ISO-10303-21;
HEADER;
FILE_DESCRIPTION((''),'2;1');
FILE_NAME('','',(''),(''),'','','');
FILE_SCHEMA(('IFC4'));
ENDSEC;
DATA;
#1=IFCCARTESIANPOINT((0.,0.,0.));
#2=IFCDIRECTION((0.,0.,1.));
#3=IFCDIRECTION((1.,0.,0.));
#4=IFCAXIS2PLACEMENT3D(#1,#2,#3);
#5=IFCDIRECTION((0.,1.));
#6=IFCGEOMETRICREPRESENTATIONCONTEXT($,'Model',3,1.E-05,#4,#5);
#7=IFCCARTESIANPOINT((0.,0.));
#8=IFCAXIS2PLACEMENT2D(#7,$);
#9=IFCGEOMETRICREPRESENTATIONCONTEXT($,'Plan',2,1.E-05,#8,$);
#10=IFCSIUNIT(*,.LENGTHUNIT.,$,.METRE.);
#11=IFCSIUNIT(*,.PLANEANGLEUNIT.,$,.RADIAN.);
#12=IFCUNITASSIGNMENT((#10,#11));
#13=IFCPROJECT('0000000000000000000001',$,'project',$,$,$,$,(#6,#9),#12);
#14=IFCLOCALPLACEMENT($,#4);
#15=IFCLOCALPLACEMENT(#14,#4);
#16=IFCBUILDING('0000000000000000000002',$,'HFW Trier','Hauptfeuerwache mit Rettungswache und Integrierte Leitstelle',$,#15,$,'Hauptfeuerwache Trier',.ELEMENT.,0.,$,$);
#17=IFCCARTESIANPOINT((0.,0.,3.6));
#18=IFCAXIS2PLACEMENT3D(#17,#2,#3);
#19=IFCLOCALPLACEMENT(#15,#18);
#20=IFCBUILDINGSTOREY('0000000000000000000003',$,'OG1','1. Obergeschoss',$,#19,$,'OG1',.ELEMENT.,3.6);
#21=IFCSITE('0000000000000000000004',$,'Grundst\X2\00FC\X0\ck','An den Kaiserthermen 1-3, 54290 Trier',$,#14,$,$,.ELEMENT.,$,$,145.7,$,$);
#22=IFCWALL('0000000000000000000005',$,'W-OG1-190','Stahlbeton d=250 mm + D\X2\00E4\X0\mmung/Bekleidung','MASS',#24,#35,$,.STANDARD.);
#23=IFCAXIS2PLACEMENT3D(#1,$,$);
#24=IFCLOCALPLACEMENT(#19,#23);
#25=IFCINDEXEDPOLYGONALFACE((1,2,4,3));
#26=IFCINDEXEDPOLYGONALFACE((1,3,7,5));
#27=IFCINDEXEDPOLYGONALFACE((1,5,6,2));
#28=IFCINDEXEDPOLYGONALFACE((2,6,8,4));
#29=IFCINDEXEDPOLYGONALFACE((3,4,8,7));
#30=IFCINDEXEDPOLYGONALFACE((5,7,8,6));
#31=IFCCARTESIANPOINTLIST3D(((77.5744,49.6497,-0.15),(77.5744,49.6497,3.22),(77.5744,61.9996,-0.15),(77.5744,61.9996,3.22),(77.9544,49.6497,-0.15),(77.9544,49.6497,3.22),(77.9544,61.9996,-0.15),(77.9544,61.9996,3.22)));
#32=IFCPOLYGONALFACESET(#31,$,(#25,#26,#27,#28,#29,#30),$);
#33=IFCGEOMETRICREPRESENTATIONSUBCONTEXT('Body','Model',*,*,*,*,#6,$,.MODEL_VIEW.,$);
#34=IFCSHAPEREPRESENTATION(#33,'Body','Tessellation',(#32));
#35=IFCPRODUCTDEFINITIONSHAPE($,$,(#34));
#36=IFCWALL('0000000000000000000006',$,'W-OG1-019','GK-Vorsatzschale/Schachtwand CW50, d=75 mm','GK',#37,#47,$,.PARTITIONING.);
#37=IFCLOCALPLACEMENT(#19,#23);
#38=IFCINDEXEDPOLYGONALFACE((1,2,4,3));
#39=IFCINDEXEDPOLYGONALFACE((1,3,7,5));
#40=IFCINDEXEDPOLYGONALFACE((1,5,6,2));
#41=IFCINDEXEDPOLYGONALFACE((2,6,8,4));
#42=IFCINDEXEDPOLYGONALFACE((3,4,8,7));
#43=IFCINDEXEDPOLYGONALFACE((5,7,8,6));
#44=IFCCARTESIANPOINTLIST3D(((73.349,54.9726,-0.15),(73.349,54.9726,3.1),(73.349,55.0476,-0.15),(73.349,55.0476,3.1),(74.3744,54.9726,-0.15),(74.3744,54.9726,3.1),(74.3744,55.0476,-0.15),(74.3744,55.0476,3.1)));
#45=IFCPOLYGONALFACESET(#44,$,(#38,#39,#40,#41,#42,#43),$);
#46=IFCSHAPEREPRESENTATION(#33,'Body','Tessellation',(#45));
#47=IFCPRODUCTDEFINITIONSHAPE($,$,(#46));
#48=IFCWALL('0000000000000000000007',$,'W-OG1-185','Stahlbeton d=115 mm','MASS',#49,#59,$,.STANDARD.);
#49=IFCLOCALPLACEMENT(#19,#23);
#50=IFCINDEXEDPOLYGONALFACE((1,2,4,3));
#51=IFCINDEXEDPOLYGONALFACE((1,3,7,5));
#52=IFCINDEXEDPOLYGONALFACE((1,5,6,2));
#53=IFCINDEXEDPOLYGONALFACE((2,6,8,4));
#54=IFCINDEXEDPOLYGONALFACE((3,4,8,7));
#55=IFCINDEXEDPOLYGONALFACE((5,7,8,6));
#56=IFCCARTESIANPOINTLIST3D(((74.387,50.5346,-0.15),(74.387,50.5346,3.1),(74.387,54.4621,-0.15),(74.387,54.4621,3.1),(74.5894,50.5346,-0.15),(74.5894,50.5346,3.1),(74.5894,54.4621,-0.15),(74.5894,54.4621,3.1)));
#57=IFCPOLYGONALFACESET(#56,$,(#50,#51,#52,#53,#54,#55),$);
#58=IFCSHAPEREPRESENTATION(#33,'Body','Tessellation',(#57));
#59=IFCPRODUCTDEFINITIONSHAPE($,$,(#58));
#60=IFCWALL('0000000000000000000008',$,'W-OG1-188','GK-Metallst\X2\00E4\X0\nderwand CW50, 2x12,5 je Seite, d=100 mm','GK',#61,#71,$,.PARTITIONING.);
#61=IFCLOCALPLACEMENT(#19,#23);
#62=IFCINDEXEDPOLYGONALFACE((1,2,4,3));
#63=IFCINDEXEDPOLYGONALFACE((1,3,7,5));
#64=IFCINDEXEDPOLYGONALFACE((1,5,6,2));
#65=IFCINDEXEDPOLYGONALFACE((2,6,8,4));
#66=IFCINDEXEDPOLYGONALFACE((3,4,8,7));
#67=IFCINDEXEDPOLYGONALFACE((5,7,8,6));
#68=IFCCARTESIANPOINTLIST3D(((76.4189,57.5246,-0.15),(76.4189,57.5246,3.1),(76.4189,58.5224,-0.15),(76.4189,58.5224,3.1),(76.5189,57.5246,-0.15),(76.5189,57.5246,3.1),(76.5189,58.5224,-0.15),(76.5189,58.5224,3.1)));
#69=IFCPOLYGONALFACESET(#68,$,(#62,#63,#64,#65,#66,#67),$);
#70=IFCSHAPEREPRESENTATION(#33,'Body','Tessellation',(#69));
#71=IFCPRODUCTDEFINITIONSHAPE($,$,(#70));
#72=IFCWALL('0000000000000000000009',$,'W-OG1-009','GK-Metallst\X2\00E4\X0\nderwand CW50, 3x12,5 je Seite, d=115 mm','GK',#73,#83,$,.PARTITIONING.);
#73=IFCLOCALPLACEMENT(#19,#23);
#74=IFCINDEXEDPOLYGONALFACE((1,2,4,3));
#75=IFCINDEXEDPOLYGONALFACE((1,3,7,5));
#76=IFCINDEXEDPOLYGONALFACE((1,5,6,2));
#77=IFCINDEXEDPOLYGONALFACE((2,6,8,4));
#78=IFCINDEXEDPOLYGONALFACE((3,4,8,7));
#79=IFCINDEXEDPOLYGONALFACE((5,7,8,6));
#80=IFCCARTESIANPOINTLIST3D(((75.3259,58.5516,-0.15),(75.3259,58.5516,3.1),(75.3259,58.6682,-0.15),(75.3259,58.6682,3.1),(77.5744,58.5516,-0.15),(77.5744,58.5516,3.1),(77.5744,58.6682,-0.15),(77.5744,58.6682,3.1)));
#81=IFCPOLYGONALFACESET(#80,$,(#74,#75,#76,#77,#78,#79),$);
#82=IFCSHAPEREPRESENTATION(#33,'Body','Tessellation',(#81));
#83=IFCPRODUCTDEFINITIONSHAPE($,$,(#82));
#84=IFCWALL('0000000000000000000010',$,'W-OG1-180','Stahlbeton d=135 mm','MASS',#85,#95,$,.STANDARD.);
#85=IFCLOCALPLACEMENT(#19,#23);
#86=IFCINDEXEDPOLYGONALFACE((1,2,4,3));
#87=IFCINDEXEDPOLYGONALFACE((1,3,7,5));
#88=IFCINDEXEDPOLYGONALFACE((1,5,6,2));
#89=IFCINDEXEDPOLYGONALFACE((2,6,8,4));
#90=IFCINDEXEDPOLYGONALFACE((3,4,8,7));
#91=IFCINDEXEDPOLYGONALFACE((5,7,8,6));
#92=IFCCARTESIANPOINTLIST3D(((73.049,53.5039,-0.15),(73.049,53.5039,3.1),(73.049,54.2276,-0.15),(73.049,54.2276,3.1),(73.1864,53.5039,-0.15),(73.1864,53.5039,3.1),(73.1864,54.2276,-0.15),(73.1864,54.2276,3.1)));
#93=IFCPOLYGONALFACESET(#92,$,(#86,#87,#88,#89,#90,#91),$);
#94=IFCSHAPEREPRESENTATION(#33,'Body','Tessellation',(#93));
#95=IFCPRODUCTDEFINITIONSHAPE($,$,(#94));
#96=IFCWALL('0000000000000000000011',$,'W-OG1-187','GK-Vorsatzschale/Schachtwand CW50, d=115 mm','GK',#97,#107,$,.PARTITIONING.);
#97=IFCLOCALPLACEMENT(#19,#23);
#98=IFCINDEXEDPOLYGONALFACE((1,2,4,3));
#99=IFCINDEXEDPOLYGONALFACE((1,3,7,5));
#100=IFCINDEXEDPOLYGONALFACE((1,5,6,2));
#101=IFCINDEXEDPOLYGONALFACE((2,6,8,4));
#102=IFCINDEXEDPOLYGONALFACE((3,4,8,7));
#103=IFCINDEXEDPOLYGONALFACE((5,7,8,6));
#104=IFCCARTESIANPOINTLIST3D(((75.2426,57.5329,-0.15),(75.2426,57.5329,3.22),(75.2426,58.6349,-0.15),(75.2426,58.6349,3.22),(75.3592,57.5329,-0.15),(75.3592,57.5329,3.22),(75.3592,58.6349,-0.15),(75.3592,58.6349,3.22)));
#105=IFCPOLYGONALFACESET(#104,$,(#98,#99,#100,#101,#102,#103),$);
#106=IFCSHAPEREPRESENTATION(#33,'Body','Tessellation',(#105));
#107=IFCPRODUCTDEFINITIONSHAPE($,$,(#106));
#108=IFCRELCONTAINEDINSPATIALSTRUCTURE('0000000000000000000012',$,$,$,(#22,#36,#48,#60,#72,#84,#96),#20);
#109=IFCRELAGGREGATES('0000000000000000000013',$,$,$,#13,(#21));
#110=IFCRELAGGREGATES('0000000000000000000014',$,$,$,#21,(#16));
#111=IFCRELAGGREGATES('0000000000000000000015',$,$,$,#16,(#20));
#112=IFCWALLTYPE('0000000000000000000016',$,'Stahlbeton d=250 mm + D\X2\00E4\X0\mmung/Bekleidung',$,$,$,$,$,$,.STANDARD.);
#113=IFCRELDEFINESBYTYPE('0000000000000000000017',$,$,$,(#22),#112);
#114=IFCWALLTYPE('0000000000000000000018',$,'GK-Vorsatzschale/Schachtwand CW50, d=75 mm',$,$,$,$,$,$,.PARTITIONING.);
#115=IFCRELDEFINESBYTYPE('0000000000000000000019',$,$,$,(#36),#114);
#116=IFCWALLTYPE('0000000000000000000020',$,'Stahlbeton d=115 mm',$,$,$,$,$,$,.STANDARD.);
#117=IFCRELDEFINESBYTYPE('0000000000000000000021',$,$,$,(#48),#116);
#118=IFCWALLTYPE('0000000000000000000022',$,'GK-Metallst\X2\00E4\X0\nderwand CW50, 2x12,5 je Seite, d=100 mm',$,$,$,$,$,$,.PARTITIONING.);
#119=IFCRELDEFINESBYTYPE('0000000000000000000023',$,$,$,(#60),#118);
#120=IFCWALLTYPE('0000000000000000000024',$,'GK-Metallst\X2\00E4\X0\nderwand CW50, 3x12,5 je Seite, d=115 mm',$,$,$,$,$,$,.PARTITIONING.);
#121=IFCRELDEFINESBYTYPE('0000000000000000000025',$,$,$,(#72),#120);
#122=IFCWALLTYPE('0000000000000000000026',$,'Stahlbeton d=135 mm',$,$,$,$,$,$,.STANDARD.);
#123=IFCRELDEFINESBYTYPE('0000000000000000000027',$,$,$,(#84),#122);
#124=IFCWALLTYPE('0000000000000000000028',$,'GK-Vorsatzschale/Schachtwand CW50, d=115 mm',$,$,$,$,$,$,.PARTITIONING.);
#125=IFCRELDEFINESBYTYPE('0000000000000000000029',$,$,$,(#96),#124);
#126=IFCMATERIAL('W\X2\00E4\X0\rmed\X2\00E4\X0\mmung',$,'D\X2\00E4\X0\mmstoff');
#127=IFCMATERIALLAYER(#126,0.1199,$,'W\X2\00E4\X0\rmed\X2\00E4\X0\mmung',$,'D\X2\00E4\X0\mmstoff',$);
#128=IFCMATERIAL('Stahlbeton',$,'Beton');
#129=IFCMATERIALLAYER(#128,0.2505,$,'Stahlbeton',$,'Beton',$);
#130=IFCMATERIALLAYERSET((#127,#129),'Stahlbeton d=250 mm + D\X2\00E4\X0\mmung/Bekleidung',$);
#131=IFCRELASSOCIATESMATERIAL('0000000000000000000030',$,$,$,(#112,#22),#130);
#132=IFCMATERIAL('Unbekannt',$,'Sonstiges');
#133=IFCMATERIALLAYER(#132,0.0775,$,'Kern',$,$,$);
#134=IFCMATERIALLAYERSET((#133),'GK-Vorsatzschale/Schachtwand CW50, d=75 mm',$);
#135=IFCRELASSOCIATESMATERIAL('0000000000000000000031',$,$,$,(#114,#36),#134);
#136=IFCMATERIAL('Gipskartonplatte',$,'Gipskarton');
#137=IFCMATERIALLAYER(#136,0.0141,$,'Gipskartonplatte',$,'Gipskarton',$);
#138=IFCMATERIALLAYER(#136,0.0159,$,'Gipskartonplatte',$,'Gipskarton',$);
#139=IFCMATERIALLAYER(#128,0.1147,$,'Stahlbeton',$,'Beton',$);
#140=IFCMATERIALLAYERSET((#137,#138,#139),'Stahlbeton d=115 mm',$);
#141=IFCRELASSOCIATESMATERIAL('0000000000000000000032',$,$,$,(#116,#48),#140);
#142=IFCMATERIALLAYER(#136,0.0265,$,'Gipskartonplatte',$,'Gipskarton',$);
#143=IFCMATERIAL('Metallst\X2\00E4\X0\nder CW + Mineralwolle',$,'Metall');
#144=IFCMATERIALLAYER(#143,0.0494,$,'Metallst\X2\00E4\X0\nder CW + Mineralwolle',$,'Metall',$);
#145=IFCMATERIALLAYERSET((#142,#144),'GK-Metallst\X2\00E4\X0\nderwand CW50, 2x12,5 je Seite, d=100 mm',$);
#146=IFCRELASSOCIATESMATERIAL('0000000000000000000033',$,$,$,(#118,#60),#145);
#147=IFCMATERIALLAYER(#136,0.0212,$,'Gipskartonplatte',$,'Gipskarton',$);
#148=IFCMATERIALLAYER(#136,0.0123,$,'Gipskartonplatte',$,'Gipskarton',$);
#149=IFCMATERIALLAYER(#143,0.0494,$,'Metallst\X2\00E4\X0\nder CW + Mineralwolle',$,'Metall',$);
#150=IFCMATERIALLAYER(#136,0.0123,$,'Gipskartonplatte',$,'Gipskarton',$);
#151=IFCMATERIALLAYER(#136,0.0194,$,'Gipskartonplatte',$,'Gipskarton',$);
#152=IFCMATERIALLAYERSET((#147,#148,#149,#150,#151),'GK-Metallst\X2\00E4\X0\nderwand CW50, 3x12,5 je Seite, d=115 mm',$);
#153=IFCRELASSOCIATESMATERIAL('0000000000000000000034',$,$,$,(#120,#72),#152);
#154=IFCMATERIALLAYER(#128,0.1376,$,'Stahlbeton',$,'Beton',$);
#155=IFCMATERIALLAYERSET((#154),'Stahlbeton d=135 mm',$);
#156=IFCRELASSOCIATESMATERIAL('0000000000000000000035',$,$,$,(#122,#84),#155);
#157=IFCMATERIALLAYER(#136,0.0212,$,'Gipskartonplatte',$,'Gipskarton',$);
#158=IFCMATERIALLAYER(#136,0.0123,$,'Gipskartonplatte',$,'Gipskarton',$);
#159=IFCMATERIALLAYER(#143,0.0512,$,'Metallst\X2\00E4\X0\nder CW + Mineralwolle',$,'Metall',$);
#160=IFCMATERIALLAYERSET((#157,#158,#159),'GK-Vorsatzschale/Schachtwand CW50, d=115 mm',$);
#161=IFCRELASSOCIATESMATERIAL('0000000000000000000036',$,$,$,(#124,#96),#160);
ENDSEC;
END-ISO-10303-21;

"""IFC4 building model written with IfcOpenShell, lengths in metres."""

from ifc_helpers import new_model, si_unit, direction, frame, frame_2d, origin_with_axes, origin_2d, place, context, subcontext, project, spatial, rectangle, extrude, material, layer, layer_set, layer_usage, type_object, element, save


model = new_model("IFC4")

# Units and contexts
model_context = context("Model", 3, precision=1e-05, world=origin_with_axes(), true_north=direction((0.0, 1.0)))
plan_context = context("Plan", 2, precision=1e-05, world=origin_2d())
body_context = subcontext(model_context, "Body", "Model", "MODEL_VIEW")
ifc_project = project(units=[si_unit("LENGTHUNIT", "METRE"), si_unit("PLANEANGLEUNIT", "RADIAN")], contexts=[model_context, plan_context])

# Site, building, storey
site_placement = place(None, origin_with_axes())
site = spatial("IfcSite", under=ifc_project, at=site_placement, Name="Grundstück", Description="An den Kaiserthermen 1-3, 54290 Trier", CompositionType="ELEMENT", RefElevation=145.7)
building_placement = place(site_placement, origin_with_axes())
building = spatial("IfcBuilding", under=site, at=building_placement, Name="HFW Trier", Description="Hauptfeuerwache mit Rettungswache und Integrierte Leitstelle", LongName="Hauptfeuerwache Trier", CompositionType="ELEMENT", ElevationOfRefHeight=0.0)
storey_placement = place(building_placement, frame((0.0, 0.0, 3.6), z_axis=(0.0, 0.0, 1.0), x_axis=(1.0, 0.0, 0.0)))
storey = spatial("IfcBuildingStorey", under=building, at=storey_placement, Name="OG1", Description="1. Obergeschoss", LongName="OG1", CompositionType="ELEMENT", Elevation=3.6)

# Shared definitions
ifc_material_1 = material(Name="Gipskartonplatte", Category="Gipskarton")
ifc_material_2 = material(Name="Metallständer CW + Mineralwolle", Category="Metall")

# Shared definitions
ifc_material_3 = material(Name="Stahlbeton", Category="Beton")

# Walls
ifc_material_4 = material(Name="Wärmedämmung", Category="Dämmstoff")
ifc_layer_1 = layer(ifc_material_4, 0.1199, Name="Wärmedämmung", Category="Dämmstoff")
ifc_layer_2 = layer(ifc_material_3, 0.2505, Name="Stahlbeton", Category="Beton")
ifc_layer_set_1 = layer_set([ifc_layer_1, ifc_layer_2], Name="Stahlbeton d=250 mm + Dämmung/Bekleidung")
ifc_layer_usage_1 = layer_usage(ifc_layer_set_1, "AXIS2", "POSITIVE", -0.19)
wall_type_1 = type_object("IfcWallType", Name="Stahlbeton d=250 mm + Dämmung/Bekleidung", PredefinedType="STANDARD", material=ifc_layer_set_1)
wall_1_placement = place(storey_placement, frame((77.7644, 61.9996, -0.15), z_axis=(0.0, 0.0, 1.0), x_axis=(0.0, -1.0, 0.0)))
element("IfcWall", 1, at=wall_1_placement, inside=storey, type_object=wall_type_1, material=ifc_layer_usage_1, Name="W-OG1-190", Description="Stahlbeton d=250 mm + Dämmung/Bekleidung", ObjectType="MASS", PredefinedType="STANDARD", context=body_context, shape_type="SweptSolid", body=[
    extrude(rectangle(XDim=12.3499, YDim=0.38, at=frame_2d((6.1749, 0.0))), origin_with_axes(), (0.0, 0.0, 1.0), 3.37),
])
ifc_material_5 = material(Name="Unbekannt", Category="Sonstiges")
ifc_layer_3 = layer(ifc_material_5, 0.0775, Name="Kern")
ifc_layer_set_2 = layer_set([ifc_layer_3], Name="GK-Vorsatzschale/Schachtwand CW50, d=75 mm")
ifc_layer_usage_2 = layer_usage(ifc_layer_set_2, "AXIS2", "POSITIVE", -0.0375)
wall_type_2 = type_object("IfcWallType", Name="GK-Vorsatzschale/Schachtwand CW50, d=75 mm", PredefinedType="PARTITIONING", material=ifc_layer_set_2)
wall_2_placement = place(storey_placement, frame((73.349, 55.0101, -0.15), z_axis=(0.0, 0.0, 1.0), x_axis=(1.0, 0.0, 0.0)))
element("IfcWall", 2, at=wall_2_placement, inside=storey, type_object=wall_type_2, material=ifc_layer_usage_2, Name="W-OG1-019", Description="GK-Vorsatzschale/Schachtwand CW50, d=75 mm", ObjectType="GK", PredefinedType="PARTITIONING", context=body_context, shape_type="SweptSolid", body=[
    extrude(rectangle(XDim=1.0254, YDim=0.075, at=frame_2d((0.5127, 0.0))), origin_with_axes(), (0.0, 0.0, 1.0), 3.25),
])
ifc_layer_4 = layer(ifc_material_1, 0.0141, Name="Gipskartonplatte", Category="Gipskarton")
ifc_layer_5 = layer(ifc_material_1, 0.0159, Name="Gipskartonplatte", Category="Gipskarton")
ifc_layer_6 = layer(ifc_material_3, 0.1147, Name="Stahlbeton", Category="Beton")
ifc_layer_set_3 = layer_set([ifc_layer_4, ifc_layer_5, ifc_layer_6], Name="Stahlbeton d=115 mm")
ifc_layer_usage_3 = layer_usage(ifc_layer_set_3, "AXIS2", "POSITIVE", -0.1013)
wall_type_3 = type_object("IfcWallType", Name="Stahlbeton d=115 mm", PredefinedType="STANDARD", material=ifc_layer_set_3)
wall_3_placement = place(storey_placement, frame((74.4882, 54.4621, -0.15), z_axis=(0.0, 0.0, 1.0), x_axis=(0.0, -1.0, 0.0)))
element("IfcWall", 3, at=wall_3_placement, inside=storey, type_object=wall_type_3, material=ifc_layer_usage_3, Name="W-OG1-185", Description="Stahlbeton d=115 mm", ObjectType="MASS", PredefinedType="STANDARD", context=body_context, shape_type="SweptSolid", body=[
    extrude(rectangle(XDim=3.9275, YDim=0.2025, at=frame_2d((1.9638, 0.0))), origin_with_axes(), (0.0, 0.0, 1.0), 3.25),
])
ifc_layer_7 = layer(ifc_material_1, 0.0265, Name="Gipskartonplatte", Category="Gipskarton")
ifc_layer_8 = layer(ifc_material_2, 0.0494, Name="Metallständer CW + Mineralwolle", Category="Metall")
ifc_layer_set_4 = layer_set([ifc_layer_7, ifc_layer_8], Name="GK-Metallständerwand CW50, 2x12,5 je Seite, d=100 mm")
ifc_layer_usage_4 = layer_usage(ifc_layer_set_4, "AXIS2", "POSITIVE", -0.05)
wall_type_4 = type_object("IfcWallType", Name="GK-Metallständerwand CW50, 2x12,5 je Seite, d=100 mm", PredefinedType="PARTITIONING", material=ifc_layer_set_4)
wall_4_placement = place(storey_placement, frame((76.4689, 58.5224, -0.15), z_axis=(0.0, 0.0, 1.0), x_axis=(0.0, -1.0, 0.0)))
element("IfcWall", 4, at=wall_4_placement, inside=storey, type_object=wall_type_4, material=ifc_layer_usage_4, Name="W-OG1-188", Description="GK-Metallständerwand CW50, 2x12,5 je Seite, d=100 mm", ObjectType="GK", PredefinedType="PARTITIONING", context=body_context, shape_type="SweptSolid", body=[
    extrude(rectangle(XDim=0.9978, YDim=0.1, at=frame_2d((0.4989, 0.0))), origin_with_axes(), (0.0, 0.0, 1.0), 3.25),
])
ifc_layer_9 = layer(ifc_material_1, 0.0212, Name="Gipskartonplatte", Category="Gipskarton")
ifc_layer_10 = layer(ifc_material_1, 0.0123, Name="Gipskartonplatte", Category="Gipskarton")
ifc_layer_11 = layer(ifc_material_2, 0.0494, Name="Metallständer CW + Mineralwolle", Category="Metall")
ifc_layer_12 = layer(ifc_material_1, 0.0123, Name="Gipskartonplatte", Category="Gipskarton")
ifc_layer_13 = layer(ifc_material_1, 0.0194, Name="Gipskartonplatte", Category="Gipskarton")
ifc_layer_set_5 = layer_set([ifc_layer_9, ifc_layer_10, ifc_layer_11, ifc_layer_12, ifc_layer_13], Name="GK-Metallständerwand CW50, 3x12,5 je Seite, d=115 mm")
ifc_layer_usage_5 = layer_usage(ifc_layer_set_5, "AXIS2", "POSITIVE", -0.0583)
wall_type_5 = type_object("IfcWallType", Name="GK-Metallständerwand CW50, 3x12,5 je Seite, d=115 mm", PredefinedType="PARTITIONING", material=ifc_layer_set_5)
wall_5_placement = place(storey_placement, frame((75.3259, 58.6099, -0.15), z_axis=(0.0, 0.0, 1.0), x_axis=(1.0, 0.0, 0.0)))
element("IfcWall", 5, at=wall_5_placement, inside=storey, type_object=wall_type_5, material=ifc_layer_usage_5, Name="W-OG1-009", Description="GK-Metallständerwand CW50, 3x12,5 je Seite, d=115 mm", ObjectType="GK", PredefinedType="PARTITIONING", context=body_context, shape_type="SweptSolid", body=[
    extrude(rectangle(XDim=2.2485, YDim=0.1166, at=frame_2d((1.1242, 0.0))), origin_with_axes(), (0.0, 0.0, 1.0), 3.25),
])
ifc_layer_14 = layer(ifc_material_3, 0.1376, Name="Stahlbeton", Category="Beton")
ifc_layer_set_6 = layer_set([ifc_layer_14], Name="Stahlbeton d=135 mm")
ifc_layer_usage_6 = layer_usage(ifc_layer_set_6, "AXIS2", "POSITIVE", -0.0687)
wall_type_6 = type_object("IfcWallType", Name="Stahlbeton d=135 mm", PredefinedType="STANDARD", material=ifc_layer_set_6)
wall_6_placement = place(storey_placement, frame((73.1177, 54.2276, -0.15), z_axis=(0.0, 0.0, 1.0), x_axis=(0.0, -1.0, 0.0)))
element("IfcWall", 6, at=wall_6_placement, inside=storey, type_object=wall_type_6, material=ifc_layer_usage_6, Name="W-OG1-180", Description="Stahlbeton d=135 mm", ObjectType="MASS", PredefinedType="STANDARD", context=body_context, shape_type="SweptSolid", body=[
    extrude(rectangle(XDim=0.7237, YDim=0.1373, at=frame_2d((0.3619, 0.0))), origin_with_axes(), (0.0, 0.0, 1.0), 3.25),
])
ifc_layer_15 = layer(ifc_material_1, 0.0212, Name="Gipskartonplatte", Category="Gipskarton")
ifc_layer_16 = layer(ifc_material_1, 0.0123, Name="Gipskartonplatte", Category="Gipskarton")
ifc_layer_17 = layer(ifc_material_2, 0.0512, Name="Metallständer CW + Mineralwolle", Category="Metall")
ifc_layer_set_7 = layer_set([ifc_layer_15, ifc_layer_16, ifc_layer_17], Name="GK-Vorsatzschale/Schachtwand CW50, d=115 mm")
ifc_layer_usage_7 = layer_usage(ifc_layer_set_7, "AXIS2", "POSITIVE", -0.0583)
wall_type_7 = type_object("IfcWallType", Name="GK-Vorsatzschale/Schachtwand CW50, d=115 mm", PredefinedType="PARTITIONING", material=ifc_layer_set_7)
wall_7_placement = place(storey_placement, frame((75.3009, 58.6349, -0.15), z_axis=(0.0, 0.0, 1.0), x_axis=(0.0, -1.0, 0.0)))
element("IfcWall", 7, at=wall_7_placement, inside=storey, type_object=wall_type_7, material=ifc_layer_usage_7, Name="W-OG1-187", Description="GK-Vorsatzschale/Schachtwand CW50, d=115 mm", ObjectType="GK", PredefinedType="PARTITIONING", context=body_context, shape_type="SweptSolid", body=[
    extrude(rectangle(XDim=1.102, YDim=0.1166, at=frame_2d((0.551, 0.0))), origin_with_axes(), (0.0, 0.0, 1.0), 3.37),
])

save(model, "model.ifc")
